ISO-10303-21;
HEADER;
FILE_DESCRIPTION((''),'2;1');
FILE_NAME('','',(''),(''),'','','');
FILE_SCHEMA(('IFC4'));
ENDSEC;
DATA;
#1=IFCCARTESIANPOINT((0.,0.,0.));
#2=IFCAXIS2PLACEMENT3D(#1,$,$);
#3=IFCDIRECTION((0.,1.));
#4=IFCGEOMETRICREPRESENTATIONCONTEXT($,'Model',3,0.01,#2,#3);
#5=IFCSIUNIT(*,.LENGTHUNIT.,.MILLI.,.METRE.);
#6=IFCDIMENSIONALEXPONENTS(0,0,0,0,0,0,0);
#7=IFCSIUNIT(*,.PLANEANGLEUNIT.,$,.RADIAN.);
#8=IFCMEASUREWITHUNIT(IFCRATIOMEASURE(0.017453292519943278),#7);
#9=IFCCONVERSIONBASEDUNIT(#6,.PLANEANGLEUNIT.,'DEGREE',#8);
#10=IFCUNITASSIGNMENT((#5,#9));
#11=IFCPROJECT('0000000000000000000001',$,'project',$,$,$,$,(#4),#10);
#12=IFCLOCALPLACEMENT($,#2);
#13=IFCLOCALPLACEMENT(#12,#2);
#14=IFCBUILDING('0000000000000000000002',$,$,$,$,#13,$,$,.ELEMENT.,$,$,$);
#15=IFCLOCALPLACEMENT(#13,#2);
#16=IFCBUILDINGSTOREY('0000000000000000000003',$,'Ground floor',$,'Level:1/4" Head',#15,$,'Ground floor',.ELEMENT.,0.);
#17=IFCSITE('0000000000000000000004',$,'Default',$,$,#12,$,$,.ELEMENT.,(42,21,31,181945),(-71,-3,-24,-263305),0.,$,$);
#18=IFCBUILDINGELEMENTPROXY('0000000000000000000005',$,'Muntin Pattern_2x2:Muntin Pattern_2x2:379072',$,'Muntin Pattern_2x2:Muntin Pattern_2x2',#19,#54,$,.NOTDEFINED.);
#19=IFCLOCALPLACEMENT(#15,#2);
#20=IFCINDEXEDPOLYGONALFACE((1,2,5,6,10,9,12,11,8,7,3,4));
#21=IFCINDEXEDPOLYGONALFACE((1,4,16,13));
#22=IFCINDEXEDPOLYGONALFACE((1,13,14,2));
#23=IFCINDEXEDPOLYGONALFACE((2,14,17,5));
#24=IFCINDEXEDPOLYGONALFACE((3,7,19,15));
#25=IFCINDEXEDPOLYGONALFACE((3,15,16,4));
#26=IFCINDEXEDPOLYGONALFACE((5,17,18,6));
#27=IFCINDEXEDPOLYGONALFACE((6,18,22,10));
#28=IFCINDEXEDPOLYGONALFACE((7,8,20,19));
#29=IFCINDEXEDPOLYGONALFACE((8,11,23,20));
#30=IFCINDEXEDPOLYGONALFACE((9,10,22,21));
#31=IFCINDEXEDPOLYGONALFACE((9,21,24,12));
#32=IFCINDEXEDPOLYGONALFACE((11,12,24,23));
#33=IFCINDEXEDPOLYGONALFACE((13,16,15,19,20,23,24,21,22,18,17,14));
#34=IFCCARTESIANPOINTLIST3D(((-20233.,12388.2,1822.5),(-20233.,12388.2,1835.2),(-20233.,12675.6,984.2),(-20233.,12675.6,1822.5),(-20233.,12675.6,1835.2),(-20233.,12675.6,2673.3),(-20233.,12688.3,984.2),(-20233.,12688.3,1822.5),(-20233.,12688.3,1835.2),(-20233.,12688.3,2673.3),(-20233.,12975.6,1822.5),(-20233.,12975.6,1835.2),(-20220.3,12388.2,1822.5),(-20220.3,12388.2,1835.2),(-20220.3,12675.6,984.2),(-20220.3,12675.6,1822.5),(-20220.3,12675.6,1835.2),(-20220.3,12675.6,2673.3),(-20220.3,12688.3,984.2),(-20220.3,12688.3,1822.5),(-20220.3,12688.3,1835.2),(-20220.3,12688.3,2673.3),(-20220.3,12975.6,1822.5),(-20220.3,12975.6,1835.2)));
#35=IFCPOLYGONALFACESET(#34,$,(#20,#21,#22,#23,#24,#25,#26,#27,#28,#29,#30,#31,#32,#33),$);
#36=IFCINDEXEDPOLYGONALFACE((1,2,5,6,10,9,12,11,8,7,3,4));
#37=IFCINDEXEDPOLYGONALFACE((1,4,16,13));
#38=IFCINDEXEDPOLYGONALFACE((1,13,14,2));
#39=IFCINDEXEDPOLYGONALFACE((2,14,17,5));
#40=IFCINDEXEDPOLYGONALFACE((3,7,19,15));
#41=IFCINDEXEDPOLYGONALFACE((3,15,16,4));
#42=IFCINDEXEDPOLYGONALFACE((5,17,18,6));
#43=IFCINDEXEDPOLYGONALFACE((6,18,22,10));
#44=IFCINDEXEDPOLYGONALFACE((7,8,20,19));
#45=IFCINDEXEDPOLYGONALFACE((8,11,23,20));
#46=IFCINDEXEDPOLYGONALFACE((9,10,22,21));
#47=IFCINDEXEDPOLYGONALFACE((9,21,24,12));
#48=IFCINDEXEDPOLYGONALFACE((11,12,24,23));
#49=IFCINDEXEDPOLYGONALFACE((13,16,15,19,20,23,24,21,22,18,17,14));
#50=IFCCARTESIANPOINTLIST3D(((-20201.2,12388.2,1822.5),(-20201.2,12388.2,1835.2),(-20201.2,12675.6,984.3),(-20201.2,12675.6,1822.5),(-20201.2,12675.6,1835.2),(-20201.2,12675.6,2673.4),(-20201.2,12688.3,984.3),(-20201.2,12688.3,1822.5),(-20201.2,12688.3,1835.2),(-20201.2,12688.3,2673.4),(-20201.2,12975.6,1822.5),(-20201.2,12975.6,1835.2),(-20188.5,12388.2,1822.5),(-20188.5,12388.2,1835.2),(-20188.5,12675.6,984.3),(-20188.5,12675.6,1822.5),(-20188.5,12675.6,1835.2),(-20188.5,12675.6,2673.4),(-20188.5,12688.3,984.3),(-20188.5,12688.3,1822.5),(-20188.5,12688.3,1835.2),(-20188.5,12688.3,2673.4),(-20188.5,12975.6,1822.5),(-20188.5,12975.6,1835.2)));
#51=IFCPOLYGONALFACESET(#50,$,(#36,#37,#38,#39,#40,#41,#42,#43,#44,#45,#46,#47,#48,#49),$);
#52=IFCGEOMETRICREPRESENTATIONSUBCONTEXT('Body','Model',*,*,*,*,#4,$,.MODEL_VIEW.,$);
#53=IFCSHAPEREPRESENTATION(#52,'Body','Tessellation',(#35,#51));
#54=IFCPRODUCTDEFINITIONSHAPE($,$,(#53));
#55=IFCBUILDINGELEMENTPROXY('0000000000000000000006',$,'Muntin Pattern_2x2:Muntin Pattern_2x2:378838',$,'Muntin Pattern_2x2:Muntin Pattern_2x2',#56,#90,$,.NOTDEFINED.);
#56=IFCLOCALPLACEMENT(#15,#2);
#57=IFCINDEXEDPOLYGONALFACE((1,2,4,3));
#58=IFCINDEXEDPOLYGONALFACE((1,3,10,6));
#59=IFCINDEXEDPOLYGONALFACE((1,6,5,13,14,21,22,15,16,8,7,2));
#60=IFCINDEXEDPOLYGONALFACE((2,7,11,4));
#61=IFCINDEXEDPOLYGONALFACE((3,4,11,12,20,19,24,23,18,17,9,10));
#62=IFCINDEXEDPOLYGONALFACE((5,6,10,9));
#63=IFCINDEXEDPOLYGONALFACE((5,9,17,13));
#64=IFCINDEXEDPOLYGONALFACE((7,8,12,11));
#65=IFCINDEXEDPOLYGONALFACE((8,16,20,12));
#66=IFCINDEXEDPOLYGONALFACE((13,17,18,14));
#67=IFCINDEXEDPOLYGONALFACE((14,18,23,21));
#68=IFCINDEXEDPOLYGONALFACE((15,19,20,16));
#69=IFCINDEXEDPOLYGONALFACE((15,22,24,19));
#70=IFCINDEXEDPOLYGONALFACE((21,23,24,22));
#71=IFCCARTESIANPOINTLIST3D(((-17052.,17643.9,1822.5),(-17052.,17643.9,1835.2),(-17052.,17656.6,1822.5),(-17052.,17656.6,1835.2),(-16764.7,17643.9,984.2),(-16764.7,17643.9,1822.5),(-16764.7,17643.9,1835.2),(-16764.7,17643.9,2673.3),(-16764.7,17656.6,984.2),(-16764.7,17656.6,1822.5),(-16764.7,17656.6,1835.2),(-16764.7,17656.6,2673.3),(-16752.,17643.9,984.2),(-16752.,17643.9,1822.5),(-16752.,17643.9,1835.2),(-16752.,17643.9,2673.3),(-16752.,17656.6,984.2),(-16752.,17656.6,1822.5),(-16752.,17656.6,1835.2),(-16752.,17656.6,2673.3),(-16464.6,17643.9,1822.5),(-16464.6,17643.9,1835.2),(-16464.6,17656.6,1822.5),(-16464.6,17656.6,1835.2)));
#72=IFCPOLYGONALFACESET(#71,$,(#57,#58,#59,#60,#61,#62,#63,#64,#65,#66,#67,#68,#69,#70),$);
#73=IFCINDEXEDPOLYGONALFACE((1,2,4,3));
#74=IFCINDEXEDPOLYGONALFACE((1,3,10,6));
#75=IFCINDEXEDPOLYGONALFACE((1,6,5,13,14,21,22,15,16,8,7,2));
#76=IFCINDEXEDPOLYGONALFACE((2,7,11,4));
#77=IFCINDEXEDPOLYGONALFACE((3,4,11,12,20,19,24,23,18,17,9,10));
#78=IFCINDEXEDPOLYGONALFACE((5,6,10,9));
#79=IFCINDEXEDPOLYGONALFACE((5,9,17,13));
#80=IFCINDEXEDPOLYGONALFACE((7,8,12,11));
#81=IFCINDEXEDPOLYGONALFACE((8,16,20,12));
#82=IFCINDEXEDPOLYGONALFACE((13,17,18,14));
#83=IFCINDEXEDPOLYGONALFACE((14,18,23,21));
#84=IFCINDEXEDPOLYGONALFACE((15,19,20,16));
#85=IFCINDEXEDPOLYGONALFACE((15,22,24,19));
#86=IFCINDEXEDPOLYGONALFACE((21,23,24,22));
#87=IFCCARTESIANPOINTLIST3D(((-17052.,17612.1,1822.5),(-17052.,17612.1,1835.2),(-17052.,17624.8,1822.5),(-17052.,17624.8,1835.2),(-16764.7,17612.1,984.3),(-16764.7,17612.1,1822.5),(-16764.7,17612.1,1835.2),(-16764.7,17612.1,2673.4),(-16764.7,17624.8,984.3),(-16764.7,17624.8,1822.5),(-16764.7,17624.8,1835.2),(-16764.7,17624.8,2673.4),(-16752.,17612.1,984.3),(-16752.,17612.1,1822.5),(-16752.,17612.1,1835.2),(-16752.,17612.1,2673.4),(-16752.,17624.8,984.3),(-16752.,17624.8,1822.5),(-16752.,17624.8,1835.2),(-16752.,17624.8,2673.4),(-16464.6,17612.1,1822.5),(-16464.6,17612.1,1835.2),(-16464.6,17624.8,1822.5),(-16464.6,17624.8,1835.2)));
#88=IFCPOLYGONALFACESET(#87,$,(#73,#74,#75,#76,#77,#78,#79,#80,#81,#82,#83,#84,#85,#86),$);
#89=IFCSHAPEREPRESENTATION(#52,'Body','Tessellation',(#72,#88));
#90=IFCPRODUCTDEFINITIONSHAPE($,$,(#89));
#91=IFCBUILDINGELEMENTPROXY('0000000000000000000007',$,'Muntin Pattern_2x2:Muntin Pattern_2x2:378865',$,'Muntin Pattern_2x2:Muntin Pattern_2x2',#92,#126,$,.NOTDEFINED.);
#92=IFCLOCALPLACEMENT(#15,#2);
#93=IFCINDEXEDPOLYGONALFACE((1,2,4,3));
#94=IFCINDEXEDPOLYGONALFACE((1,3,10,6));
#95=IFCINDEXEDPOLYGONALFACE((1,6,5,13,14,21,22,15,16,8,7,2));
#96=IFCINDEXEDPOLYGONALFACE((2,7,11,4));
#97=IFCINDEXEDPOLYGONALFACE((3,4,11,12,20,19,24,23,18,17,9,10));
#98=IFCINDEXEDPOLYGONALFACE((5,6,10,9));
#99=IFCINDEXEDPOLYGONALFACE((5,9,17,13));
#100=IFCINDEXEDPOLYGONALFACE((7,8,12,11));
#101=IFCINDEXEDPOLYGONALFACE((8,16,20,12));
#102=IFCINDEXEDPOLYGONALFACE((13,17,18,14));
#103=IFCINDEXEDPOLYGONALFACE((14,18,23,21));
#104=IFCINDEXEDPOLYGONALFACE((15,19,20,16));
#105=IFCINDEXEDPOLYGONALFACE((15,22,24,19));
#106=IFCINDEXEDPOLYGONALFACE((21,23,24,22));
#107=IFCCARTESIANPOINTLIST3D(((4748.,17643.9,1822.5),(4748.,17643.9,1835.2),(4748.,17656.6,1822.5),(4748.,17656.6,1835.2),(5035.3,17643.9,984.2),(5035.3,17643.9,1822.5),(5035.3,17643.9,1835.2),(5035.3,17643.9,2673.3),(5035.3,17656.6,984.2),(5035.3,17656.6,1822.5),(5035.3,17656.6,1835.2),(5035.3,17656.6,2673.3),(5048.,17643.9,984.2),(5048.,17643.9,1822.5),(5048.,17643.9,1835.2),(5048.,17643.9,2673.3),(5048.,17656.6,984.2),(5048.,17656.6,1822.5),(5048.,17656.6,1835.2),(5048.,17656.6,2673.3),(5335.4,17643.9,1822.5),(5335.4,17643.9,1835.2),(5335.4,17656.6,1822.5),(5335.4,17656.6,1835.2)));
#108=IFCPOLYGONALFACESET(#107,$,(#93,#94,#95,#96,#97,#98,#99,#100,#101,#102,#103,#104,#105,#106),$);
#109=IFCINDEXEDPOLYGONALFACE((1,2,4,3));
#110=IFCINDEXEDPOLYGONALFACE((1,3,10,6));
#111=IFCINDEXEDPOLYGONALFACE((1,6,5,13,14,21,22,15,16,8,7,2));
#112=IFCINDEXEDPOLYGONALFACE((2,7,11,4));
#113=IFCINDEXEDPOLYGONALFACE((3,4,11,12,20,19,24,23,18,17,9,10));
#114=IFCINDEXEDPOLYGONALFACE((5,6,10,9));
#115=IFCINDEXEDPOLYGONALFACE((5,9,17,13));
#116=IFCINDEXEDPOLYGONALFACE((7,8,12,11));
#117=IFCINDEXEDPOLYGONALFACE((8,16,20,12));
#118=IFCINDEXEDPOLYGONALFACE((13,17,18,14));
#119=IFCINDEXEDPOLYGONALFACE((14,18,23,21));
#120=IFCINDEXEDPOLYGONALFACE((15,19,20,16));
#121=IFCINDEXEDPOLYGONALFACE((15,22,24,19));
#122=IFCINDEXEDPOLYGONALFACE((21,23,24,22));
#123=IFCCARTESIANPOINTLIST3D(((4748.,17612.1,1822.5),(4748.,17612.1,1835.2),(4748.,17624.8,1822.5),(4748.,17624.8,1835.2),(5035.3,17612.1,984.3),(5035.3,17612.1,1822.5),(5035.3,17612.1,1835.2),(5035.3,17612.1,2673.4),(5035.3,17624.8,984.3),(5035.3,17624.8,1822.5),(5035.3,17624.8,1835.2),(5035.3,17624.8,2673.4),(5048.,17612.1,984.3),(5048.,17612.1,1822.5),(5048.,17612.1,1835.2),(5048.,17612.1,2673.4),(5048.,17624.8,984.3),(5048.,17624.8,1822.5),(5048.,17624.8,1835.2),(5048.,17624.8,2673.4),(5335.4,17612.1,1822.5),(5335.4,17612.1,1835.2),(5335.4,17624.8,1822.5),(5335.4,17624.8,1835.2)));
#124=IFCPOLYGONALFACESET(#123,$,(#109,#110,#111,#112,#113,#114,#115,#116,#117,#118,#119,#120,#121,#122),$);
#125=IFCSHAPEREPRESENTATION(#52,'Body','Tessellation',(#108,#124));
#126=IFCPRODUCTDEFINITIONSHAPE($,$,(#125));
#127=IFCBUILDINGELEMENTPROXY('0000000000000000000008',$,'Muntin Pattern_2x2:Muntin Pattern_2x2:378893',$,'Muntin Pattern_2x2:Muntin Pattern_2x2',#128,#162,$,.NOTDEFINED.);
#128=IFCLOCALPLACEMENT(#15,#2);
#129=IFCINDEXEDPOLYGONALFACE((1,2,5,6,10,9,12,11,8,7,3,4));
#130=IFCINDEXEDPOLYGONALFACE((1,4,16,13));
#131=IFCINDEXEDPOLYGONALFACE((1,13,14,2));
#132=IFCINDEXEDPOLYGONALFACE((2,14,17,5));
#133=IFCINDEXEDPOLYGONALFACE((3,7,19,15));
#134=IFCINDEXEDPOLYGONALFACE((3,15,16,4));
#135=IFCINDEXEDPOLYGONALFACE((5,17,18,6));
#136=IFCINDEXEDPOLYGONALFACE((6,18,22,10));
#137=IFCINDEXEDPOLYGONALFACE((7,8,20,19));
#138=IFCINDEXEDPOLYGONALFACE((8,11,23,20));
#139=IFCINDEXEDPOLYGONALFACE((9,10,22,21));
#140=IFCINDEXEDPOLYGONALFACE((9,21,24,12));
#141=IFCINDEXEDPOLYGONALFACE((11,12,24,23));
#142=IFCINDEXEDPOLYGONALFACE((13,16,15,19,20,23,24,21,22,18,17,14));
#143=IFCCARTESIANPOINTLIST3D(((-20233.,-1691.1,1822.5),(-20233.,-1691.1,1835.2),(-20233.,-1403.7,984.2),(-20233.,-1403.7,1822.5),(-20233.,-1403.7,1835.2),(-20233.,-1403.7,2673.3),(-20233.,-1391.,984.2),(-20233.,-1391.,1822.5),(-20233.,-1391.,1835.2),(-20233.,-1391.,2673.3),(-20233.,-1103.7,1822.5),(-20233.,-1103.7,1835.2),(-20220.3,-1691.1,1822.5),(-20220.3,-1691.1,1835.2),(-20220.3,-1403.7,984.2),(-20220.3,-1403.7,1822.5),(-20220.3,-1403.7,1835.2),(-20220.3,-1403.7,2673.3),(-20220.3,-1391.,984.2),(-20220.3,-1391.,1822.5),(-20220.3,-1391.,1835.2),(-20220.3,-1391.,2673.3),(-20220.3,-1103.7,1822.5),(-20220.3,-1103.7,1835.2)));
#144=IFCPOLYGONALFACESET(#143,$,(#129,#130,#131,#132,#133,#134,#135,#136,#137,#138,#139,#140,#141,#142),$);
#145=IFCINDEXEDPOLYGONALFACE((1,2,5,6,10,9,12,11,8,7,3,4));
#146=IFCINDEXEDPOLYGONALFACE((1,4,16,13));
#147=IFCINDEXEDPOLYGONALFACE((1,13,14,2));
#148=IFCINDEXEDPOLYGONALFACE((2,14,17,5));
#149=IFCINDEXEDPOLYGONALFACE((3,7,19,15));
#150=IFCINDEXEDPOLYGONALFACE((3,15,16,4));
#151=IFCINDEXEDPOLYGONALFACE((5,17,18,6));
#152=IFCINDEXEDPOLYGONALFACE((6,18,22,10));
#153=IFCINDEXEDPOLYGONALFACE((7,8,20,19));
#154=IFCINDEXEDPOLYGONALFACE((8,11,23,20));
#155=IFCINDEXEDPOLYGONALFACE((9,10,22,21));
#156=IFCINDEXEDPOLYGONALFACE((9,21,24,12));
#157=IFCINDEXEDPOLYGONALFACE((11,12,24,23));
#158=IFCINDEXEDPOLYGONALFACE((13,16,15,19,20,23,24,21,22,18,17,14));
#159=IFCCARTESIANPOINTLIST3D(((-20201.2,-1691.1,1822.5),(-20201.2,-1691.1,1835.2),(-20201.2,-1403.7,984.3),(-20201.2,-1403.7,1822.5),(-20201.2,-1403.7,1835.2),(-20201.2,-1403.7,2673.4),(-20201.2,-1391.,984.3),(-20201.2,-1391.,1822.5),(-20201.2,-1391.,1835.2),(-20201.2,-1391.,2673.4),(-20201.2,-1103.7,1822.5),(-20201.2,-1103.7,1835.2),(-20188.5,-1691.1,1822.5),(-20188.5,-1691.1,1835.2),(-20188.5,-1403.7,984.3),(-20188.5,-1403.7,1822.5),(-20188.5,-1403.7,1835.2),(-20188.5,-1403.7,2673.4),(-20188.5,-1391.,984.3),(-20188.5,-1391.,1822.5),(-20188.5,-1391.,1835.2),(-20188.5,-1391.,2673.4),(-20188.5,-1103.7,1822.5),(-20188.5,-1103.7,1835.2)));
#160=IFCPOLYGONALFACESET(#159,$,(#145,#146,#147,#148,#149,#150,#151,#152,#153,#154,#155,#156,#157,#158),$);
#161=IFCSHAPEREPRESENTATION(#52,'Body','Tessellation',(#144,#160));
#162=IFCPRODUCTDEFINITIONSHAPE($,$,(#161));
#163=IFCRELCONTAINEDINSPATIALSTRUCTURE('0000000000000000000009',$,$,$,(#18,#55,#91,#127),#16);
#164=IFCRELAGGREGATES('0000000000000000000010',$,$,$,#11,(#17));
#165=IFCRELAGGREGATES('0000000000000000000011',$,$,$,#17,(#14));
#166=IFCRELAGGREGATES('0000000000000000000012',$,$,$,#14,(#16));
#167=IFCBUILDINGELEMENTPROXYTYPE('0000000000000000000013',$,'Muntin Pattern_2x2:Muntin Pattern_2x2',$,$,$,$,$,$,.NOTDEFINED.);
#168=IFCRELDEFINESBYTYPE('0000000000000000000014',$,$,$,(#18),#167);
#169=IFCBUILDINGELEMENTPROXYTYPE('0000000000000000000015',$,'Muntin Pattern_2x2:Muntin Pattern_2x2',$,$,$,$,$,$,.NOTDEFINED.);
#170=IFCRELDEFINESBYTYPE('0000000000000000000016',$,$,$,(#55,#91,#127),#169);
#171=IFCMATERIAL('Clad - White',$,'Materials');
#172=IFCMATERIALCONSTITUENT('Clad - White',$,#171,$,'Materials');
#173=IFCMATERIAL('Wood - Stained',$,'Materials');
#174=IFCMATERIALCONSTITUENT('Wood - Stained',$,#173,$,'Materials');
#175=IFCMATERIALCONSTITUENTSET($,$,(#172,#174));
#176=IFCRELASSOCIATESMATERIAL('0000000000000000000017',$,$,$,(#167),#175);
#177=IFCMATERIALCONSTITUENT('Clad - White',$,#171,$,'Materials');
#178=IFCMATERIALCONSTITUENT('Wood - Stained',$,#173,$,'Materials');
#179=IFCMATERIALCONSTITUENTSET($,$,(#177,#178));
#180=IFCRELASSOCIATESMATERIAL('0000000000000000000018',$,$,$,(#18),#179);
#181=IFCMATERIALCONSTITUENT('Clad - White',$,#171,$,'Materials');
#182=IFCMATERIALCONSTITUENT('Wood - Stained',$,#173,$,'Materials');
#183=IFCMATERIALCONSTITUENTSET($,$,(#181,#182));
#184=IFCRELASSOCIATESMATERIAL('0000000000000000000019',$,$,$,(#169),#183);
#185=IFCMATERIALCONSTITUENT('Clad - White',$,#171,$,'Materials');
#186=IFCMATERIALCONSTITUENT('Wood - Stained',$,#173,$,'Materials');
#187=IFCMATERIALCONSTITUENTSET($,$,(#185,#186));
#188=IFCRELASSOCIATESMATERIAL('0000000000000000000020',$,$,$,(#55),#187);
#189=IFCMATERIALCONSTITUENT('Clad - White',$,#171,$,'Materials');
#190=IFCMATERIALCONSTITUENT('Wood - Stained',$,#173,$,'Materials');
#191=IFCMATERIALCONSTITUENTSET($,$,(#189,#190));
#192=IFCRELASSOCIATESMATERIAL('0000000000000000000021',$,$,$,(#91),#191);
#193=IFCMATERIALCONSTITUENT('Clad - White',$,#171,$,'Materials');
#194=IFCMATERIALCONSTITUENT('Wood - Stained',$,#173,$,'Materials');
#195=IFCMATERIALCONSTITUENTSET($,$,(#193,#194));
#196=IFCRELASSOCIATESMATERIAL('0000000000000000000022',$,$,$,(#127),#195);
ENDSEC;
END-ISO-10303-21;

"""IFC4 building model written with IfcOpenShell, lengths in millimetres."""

from ifc_helpers import new_model, entity, si_unit, converted_unit, direction, frame, origin, place, context, subcontext, project, spatial, indexed_curve, outline, extrude, source, transform, mapped, material, constituent, constituent_set, type_object, type_shapes, element, save


model = new_model("IFC4")

# Units and contexts
model_context = context("Model", 3, precision=0.01, world=origin(), true_north=direction((0.0, 1.0)))
body_context = subcontext(model_context, "Body", "Model", "MODEL_VIEW")
ifc_project = project(units=[si_unit("LENGTHUNIT", "METRE", prefix="MILLI"), converted_unit("PLANEANGLEUNIT", "DEGREE", entity("IfcRatioMeasure", 0.017453292519943278), si_unit("PLANEANGLEUNIT", "RADIAN"), dimensions=[0, 0, 0, 0, 0, 0, 0])], contexts=[model_context])

# Site, building, storey
site_placement = place(None, origin())
site = spatial("IfcSite", under=ifc_project, at=site_placement, Name="Default", CompositionType="ELEMENT", RefLatitude=(42, 21, 31, 181945), RefLongitude=(-71, -3, -24, -263305), RefElevation=0.0)
building_placement = place(site_placement, origin())
building = spatial("IfcBuilding", under=site, at=building_placement, CompositionType="ELEMENT")
storey_placement = place(building_placement, origin())
storey = spatial("IfcBuildingStorey", under=building, at=storey_placement, Name="Ground floor", ObjectType="Level:1/4\" Head", LongName="Ground floor", CompositionType="ELEMENT", Elevation=0.0)

# Building element proxies
ifc_material_1 = material(Name="Clad - White", Category="Materials")
ifc_material_2 = material(Name="Wood - Stained", Category="Materials")
ifc_constituent_1 = constituent(ifc_material_1, Name="Clad - White", Category="Materials")
ifc_constituent_2 = constituent(ifc_material_2, Name="Wood - Stained", Category="Materials")
ifc_constituent_set_1 = constituent_set(constituents=[ifc_constituent_1, ifc_constituent_2])
building_element_proxy_type_1 = type_object("IfcBuildingElementProxyType", Name="Muntin Pattern_2x2:Muntin Pattern_2x2", PredefinedType="NOTDEFINED", material=ifc_constituent_set_1)
shared_shape_1 = source(origin(), body_context, "Body", "SweptSolid", [
    extrude(outline(indexed_curve([(6.4, -6.4), (844.5, -6.4), (844.5, 6.3), (6.4, 6.3), (6.4, 293.7), (-6.3, 293.7), (-6.3, 6.3), (-844.6, 6.3), (-844.6, -6.4), (-6.3, -6.4), (-6.3, -293.7), (6.4, -293.7), (6.4, -6.4)], self_intersect=False)), frame((0.0, 9.5, 844.5), z_axis=(0.0, 1.0, 0.0), x_axis=(0.0, 0.0, 1.0)), (0.0, 0.0, 1.0), 12.7),
    extrude(outline(indexed_curve([(6.4, -6.4), (844.6, -6.4), (844.6, 6.3), (6.4, 6.3), (6.4, 293.7), (-6.3, 293.7), (-6.3, 6.3), (-844.6, 6.3), (-844.6, -6.4), (-6.3, -6.4), (-6.3, -293.7), (6.4, -293.7), (6.4, -6.4)], self_intersect=False)), frame((0.0, -22.2, 844.6), z_axis=(0.0, 1.0, 0.0), x_axis=(0.0, 0.0, 1.0)), (0.0, 0.0, 1.0), 12.7),
])
type_shapes(building_element_proxy_type_1, [shared_shape_1])
ifc_constituent_3 = constituent(ifc_material_1, Name="Clad - White", Category="Materials")
ifc_constituent_4 = constituent(ifc_material_2, Name="Wood - Stained", Category="Materials")
ifc_constituent_set_2 = constituent_set(constituents=[ifc_constituent_3, ifc_constituent_4])
proxy_1_placement = place(storey_placement, frame((-20210.8, 12681.9, 984.3), z_axis=(0.0, 0.0, 1.0), x_axis=(0.0, 1.0, 0.0)))
element("IfcBuildingElementProxy", 1, at=proxy_1_placement, inside=storey, type_object=building_element_proxy_type_1, material=ifc_constituent_set_2, Name="Muntin Pattern_2x2:Muntin Pattern_2x2:379072", ObjectType="Muntin Pattern_2x2:Muntin Pattern_2x2", PredefinedType="NOTDEFINED", context=body_context, shape_type="MappedRepresentation", body=[
    mapped(shared_shape_1, transform((0.0, 0.0, 0.0), scale=1.0)),
])
ifc_constituent_5 = constituent(ifc_material_1, Name="Clad - White", Category="Materials")
ifc_constituent_6 = constituent(ifc_material_2, Name="Wood - Stained", Category="Materials")
ifc_constituent_set_3 = constituent_set(constituents=[ifc_constituent_5, ifc_constituent_6])
ifc_constituent_7 = constituent(ifc_material_1, Name="Clad - White", Category="Materials")
ifc_constituent_8 = constituent(ifc_material_2, Name="Wood - Stained", Category="Materials")
ifc_constituent_set_4 = constituent_set(constituents=[ifc_constituent_7, ifc_constituent_8])
building_element_proxy_type_2 = type_object("IfcBuildingElementProxyType", Name="Muntin Pattern_2x2:Muntin Pattern_2x2", PredefinedType="NOTDEFINED", material=ifc_constituent_set_4)
shared_shape_2 = source(origin(), body_context, "Body", "SweptSolid", [
    extrude(outline(indexed_curve([(6.4, -6.4), (844.5, -6.4), (844.5, 6.3), (6.4, 6.3), (6.4, 293.7), (-6.3, 293.7), (-6.3, 6.3), (-844.6, 6.3), (-844.6, -6.4), (-6.3, -6.4), (-6.3, -293.7), (6.4, -293.7), (6.4, -6.4)], self_intersect=False)), frame((0.0, -22.2, 844.5), z_axis=(0.0, 1.0, 0.0), x_axis=(0.0, 0.0, 1.0)), (0.0, 0.0, 1.0), 12.7),
    extrude(outline(indexed_curve([(6.4, -6.4), (844.6, -6.4), (844.6, 6.3), (6.4, 6.3), (6.4, 293.7), (-6.3, 293.7), (-6.3, 6.3), (-844.6, 6.3), (-844.6, -6.4), (-6.3, -6.4), (-6.3, -293.7), (6.4, -293.7), (6.4, -6.4)], self_intersect=False)), frame((0.0, 9.5, 844.6), z_axis=(0.0, 1.0, 0.0), x_axis=(0.0, 0.0, 1.0)), (0.0, 0.0, 1.0), 12.7),
])
type_shapes(building_element_proxy_type_2, [shared_shape_2])
proxy_2_placement = place(storey_placement, frame((-16758.3, 17634.3, 984.3), z_axis=(0.0, 0.0, 1.0), x_axis=(-1.0, 0.0, 0.0)))
element("IfcBuildingElementProxy", 2, at=proxy_2_placement, inside=storey, type_object=building_element_proxy_type_2, material=ifc_constituent_set_3, Name="Muntin Pattern_2x2:Muntin Pattern_2x2:378838", ObjectType="Muntin Pattern_2x2:Muntin Pattern_2x2", PredefinedType="NOTDEFINED", context=body_context, shape_type="MappedRepresentation", body=[
    mapped(shared_shape_2, transform((0.0, 0.0, 0.0), scale=1.0)),
])
ifc_constituent_9 = constituent(ifc_material_1, Name="Clad - White", Category="Materials")
ifc_constituent_10 = constituent(ifc_material_2, Name="Wood - Stained", Category="Materials")
ifc_constituent_set_5 = constituent_set(constituents=[ifc_constituent_9, ifc_constituent_10])
proxy_3_placement = place(storey_placement, frame((5041.7, 17634.3, 984.3), z_axis=(0.0, 0.0, 1.0), x_axis=(-1.0, 0.0, 0.0)))
element("IfcBuildingElementProxy", 3, at=proxy_3_placement, inside=storey, type_object=building_element_proxy_type_2, material=ifc_constituent_set_5, Name="Muntin Pattern_2x2:Muntin Pattern_2x2:378865", ObjectType="Muntin Pattern_2x2:Muntin Pattern_2x2", PredefinedType="NOTDEFINED", context=body_context, shape_type="MappedRepresentation", body=[
    mapped(shared_shape_2, transform((0.0, 0.0, 0.0), scale=1.0)),
])
ifc_constituent_11 = constituent(ifc_material_1, Name="Clad - White", Category="Materials")
ifc_constituent_12 = constituent(ifc_material_2, Name="Wood - Stained", Category="Materials")
ifc_constituent_set_6 = constituent_set(constituents=[ifc_constituent_11, ifc_constituent_12])
proxy_4_placement = place(storey_placement, frame((-20210.8, -1397.4, 984.3), z_axis=(0.0, 0.0, 1.0), x_axis=(0.0, -1.0, 0.0)))
element("IfcBuildingElementProxy", 4, at=proxy_4_placement, inside=storey, type_object=building_element_proxy_type_2, material=ifc_constituent_set_6, Name="Muntin Pattern_2x2:Muntin Pattern_2x2:378893", ObjectType="Muntin Pattern_2x2:Muntin Pattern_2x2", PredefinedType="NOTDEFINED", context=body_context, shape_type="MappedRepresentation", body=[
    mapped(shared_shape_2, transform((0.0, 0.0, 0.0), scale=1.0)),
])

save(model, "model.ifc")
